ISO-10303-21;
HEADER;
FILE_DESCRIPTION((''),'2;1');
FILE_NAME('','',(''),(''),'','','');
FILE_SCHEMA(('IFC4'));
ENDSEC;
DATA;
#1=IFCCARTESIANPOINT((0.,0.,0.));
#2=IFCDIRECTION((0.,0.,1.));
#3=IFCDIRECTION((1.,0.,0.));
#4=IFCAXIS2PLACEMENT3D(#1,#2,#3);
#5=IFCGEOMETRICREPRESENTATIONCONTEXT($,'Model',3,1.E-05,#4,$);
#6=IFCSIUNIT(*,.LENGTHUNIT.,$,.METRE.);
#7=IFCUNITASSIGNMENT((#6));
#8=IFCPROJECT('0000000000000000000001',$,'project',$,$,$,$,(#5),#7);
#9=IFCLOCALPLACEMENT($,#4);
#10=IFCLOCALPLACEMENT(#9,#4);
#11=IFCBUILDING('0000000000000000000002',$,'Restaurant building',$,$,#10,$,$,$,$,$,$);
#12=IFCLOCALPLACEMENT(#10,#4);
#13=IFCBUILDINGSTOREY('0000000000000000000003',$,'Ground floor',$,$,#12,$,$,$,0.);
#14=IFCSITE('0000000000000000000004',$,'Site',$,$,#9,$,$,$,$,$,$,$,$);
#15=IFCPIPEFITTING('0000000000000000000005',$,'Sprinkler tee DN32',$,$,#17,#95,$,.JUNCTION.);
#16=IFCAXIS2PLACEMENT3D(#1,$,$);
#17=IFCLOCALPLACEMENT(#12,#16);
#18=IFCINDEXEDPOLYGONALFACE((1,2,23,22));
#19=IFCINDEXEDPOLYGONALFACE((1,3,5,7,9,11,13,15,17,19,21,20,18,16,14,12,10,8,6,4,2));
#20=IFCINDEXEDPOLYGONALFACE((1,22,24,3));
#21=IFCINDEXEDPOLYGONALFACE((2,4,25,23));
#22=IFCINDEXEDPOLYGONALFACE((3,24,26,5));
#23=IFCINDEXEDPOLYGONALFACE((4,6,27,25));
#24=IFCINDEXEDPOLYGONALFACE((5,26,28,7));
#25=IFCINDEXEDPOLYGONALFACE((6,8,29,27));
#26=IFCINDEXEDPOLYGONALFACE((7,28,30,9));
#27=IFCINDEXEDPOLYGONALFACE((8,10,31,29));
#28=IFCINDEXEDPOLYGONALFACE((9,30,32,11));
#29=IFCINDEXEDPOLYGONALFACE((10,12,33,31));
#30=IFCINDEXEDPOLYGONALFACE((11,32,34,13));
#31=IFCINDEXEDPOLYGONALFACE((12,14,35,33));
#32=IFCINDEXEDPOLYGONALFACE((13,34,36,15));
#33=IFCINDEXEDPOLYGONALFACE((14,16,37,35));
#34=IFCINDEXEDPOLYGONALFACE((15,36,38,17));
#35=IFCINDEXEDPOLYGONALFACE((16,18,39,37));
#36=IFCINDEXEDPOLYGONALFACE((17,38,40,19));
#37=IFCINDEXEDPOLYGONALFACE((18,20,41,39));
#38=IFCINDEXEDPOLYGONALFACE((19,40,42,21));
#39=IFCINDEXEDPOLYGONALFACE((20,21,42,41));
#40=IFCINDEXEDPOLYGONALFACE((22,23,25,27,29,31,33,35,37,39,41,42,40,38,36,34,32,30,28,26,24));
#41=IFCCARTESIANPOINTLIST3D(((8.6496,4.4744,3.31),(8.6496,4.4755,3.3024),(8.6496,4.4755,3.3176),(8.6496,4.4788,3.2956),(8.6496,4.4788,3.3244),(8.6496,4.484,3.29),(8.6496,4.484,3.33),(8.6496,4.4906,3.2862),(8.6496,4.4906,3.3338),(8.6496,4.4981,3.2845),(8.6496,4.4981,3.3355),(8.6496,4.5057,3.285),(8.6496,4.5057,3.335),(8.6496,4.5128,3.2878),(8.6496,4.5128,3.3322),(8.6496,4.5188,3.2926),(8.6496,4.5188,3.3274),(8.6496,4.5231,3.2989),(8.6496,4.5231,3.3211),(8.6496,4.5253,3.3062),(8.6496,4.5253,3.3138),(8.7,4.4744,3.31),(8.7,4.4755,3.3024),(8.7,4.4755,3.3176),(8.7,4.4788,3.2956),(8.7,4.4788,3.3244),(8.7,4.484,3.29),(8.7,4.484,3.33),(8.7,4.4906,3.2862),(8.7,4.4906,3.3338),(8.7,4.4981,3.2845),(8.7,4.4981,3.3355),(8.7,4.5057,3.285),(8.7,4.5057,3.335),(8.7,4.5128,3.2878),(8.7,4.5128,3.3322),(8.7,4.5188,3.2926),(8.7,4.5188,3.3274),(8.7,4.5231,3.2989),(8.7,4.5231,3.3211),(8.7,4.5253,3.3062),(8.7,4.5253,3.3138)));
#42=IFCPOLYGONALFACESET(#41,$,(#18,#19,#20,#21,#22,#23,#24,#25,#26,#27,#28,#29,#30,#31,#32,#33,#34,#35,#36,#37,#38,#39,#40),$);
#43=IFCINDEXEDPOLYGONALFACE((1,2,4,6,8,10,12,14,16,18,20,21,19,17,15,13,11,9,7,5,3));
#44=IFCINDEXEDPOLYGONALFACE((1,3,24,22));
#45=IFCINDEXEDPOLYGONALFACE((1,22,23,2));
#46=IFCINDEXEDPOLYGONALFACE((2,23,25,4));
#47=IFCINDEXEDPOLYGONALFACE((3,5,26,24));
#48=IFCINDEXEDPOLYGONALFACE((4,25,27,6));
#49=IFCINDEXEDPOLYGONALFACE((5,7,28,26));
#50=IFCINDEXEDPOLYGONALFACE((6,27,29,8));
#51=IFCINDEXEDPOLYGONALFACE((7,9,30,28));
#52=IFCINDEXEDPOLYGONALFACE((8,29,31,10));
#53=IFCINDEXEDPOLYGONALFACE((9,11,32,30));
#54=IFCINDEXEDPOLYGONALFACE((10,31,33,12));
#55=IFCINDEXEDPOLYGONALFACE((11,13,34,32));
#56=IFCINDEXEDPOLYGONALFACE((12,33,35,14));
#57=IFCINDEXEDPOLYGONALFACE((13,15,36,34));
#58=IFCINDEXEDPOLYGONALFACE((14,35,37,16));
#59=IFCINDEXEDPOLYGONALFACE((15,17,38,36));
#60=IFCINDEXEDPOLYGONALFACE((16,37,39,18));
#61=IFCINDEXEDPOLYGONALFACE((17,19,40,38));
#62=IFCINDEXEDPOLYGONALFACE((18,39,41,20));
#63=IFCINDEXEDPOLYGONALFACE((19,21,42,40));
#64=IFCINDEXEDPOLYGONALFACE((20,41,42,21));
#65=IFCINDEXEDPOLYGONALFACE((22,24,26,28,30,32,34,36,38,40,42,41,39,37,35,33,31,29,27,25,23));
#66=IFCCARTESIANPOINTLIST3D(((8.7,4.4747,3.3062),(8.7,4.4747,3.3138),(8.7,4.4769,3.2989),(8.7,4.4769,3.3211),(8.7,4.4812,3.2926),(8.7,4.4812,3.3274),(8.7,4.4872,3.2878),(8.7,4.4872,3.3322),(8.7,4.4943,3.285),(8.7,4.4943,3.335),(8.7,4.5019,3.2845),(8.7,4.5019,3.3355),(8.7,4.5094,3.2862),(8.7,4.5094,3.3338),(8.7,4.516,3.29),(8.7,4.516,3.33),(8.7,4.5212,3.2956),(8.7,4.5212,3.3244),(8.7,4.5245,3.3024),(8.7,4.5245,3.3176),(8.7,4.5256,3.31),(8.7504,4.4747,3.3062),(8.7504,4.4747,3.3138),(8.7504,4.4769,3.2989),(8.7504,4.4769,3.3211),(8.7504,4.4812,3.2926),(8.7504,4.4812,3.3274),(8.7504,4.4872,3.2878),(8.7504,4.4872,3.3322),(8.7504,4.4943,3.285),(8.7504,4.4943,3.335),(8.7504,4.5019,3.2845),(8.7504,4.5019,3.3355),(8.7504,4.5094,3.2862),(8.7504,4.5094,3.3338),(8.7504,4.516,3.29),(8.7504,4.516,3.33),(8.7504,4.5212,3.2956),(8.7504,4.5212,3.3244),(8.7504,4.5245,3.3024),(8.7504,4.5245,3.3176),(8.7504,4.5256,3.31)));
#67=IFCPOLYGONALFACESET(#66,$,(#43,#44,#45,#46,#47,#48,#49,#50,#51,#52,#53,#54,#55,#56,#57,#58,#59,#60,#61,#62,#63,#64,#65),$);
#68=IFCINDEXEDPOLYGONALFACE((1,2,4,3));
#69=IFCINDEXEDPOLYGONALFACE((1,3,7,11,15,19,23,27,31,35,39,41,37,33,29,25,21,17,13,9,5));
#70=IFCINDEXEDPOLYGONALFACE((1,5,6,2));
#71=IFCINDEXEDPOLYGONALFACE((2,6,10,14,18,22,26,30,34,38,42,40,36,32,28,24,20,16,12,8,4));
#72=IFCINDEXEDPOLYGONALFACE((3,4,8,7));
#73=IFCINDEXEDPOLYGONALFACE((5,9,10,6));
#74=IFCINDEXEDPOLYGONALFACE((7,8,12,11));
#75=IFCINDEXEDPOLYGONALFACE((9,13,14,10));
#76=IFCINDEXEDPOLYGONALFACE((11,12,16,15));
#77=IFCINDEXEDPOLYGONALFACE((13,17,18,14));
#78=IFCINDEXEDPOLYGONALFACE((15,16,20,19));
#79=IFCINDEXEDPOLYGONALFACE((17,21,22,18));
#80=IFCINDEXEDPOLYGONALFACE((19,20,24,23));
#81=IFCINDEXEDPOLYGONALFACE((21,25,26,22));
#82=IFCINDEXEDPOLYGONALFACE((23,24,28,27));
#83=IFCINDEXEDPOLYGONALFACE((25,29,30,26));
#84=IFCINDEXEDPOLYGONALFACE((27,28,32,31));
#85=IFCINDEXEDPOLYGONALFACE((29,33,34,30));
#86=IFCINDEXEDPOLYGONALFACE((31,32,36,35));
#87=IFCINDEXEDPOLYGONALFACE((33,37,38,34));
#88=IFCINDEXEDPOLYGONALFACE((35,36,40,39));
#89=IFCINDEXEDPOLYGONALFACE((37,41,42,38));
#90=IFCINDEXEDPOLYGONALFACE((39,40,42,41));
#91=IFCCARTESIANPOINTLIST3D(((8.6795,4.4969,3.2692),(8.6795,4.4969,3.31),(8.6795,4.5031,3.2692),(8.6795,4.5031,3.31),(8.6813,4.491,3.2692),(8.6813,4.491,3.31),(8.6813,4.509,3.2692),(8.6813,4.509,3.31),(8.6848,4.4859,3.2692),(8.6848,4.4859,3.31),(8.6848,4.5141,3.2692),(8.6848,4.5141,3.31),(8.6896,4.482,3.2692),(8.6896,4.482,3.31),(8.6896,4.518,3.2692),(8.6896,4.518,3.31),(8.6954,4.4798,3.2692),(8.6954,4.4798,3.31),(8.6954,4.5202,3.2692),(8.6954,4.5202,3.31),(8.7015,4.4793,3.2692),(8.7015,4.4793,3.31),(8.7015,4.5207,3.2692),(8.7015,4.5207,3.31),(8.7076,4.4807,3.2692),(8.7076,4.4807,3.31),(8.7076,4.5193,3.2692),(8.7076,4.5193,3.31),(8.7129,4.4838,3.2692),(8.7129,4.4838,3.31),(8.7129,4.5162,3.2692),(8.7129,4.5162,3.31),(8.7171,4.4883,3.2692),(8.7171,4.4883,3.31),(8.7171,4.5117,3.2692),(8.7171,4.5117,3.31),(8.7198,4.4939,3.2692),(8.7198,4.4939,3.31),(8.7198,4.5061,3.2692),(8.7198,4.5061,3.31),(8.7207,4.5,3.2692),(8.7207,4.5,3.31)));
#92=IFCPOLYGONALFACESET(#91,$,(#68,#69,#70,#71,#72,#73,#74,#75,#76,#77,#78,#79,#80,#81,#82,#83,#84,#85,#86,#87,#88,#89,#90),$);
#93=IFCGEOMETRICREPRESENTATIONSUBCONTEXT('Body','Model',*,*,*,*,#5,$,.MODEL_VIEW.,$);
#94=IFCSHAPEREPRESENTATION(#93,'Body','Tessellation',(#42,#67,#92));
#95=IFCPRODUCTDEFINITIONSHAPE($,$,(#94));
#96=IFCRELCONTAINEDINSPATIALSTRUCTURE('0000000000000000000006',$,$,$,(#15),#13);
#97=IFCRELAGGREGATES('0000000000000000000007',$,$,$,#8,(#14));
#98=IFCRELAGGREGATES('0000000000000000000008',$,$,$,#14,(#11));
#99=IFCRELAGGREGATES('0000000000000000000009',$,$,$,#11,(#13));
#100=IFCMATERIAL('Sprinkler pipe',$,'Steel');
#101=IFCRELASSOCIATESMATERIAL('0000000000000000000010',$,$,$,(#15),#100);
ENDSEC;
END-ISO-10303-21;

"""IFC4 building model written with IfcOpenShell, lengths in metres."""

from ifc_helpers import new_model, si_unit, frame, origin_with_axes, origin_2d, place, context, subcontext, project, spatial, circle, extrude, material, element, save


model = new_model("IFC4")

# Units and contexts
model_context = context("Model", 3, precision=1e-05, world=origin_with_axes())
body_context = subcontext(model_context, "Body", "Model", "MODEL_VIEW")
ifc_project = project(units=[si_unit("LENGTHUNIT", "METRE")], contexts=[model_context])

# Site, building, storey
site_placement = place(None, origin_with_axes())
site = spatial("IfcSite", under=ifc_project, at=site_placement, Name="Site")
building_placement = place(site_placement, origin_with_axes())
building = spatial("IfcBuilding", under=site, at=building_placement, Name="Restaurant building")
storey_placement = place(building_placement, origin_with_axes())
storey = spatial("IfcBuildingStorey", under=building, at=storey_placement, Name="Ground floor", Elevation=0.0)

# Shared definitions
ifc_material_1 = material(Name="Sprinkler pipe", Category="Steel")

# Pipe fitting
pipe_fitting_1_placement = place(storey_placement, frame((8.7, 4.5, 3.31)))
element("IfcPipeFitting", 1, at=pipe_fitting_1_placement, inside=storey, material=ifc_material_1, Name="Sprinkler tee DN32", PredefinedType="JUNCTION", context=body_context, shape_type="SweptSolid", body=[
    extrude(circle(Radius=0.0256, at=origin_2d()), frame((0.0, 0.0, 0.0), z_axis=(-1.0, 0.0, 0.0), x_axis=(0.0, -1.0, 0.0)), (0.0, 0.0, 1.0), 0.0504),
    extrude(circle(Radius=0.0256, at=origin_2d()), frame((0.0, 0.0, 0.0), z_axis=(1.0, 0.0, 0.0), x_axis=(0.0, 1.0, 0.0)), (0.0, 0.0, 1.0), 0.0504),
    extrude(circle(Radius=0.0207, at=origin_2d()), frame((0.0, 0.0, 0.0), z_axis=(0.0, 0.0, -1.0), x_axis=(1.0, 0.0, 0.0)), (0.0, 0.0, 1.0), 0.0408),
])

save(model, "model.ifc")
